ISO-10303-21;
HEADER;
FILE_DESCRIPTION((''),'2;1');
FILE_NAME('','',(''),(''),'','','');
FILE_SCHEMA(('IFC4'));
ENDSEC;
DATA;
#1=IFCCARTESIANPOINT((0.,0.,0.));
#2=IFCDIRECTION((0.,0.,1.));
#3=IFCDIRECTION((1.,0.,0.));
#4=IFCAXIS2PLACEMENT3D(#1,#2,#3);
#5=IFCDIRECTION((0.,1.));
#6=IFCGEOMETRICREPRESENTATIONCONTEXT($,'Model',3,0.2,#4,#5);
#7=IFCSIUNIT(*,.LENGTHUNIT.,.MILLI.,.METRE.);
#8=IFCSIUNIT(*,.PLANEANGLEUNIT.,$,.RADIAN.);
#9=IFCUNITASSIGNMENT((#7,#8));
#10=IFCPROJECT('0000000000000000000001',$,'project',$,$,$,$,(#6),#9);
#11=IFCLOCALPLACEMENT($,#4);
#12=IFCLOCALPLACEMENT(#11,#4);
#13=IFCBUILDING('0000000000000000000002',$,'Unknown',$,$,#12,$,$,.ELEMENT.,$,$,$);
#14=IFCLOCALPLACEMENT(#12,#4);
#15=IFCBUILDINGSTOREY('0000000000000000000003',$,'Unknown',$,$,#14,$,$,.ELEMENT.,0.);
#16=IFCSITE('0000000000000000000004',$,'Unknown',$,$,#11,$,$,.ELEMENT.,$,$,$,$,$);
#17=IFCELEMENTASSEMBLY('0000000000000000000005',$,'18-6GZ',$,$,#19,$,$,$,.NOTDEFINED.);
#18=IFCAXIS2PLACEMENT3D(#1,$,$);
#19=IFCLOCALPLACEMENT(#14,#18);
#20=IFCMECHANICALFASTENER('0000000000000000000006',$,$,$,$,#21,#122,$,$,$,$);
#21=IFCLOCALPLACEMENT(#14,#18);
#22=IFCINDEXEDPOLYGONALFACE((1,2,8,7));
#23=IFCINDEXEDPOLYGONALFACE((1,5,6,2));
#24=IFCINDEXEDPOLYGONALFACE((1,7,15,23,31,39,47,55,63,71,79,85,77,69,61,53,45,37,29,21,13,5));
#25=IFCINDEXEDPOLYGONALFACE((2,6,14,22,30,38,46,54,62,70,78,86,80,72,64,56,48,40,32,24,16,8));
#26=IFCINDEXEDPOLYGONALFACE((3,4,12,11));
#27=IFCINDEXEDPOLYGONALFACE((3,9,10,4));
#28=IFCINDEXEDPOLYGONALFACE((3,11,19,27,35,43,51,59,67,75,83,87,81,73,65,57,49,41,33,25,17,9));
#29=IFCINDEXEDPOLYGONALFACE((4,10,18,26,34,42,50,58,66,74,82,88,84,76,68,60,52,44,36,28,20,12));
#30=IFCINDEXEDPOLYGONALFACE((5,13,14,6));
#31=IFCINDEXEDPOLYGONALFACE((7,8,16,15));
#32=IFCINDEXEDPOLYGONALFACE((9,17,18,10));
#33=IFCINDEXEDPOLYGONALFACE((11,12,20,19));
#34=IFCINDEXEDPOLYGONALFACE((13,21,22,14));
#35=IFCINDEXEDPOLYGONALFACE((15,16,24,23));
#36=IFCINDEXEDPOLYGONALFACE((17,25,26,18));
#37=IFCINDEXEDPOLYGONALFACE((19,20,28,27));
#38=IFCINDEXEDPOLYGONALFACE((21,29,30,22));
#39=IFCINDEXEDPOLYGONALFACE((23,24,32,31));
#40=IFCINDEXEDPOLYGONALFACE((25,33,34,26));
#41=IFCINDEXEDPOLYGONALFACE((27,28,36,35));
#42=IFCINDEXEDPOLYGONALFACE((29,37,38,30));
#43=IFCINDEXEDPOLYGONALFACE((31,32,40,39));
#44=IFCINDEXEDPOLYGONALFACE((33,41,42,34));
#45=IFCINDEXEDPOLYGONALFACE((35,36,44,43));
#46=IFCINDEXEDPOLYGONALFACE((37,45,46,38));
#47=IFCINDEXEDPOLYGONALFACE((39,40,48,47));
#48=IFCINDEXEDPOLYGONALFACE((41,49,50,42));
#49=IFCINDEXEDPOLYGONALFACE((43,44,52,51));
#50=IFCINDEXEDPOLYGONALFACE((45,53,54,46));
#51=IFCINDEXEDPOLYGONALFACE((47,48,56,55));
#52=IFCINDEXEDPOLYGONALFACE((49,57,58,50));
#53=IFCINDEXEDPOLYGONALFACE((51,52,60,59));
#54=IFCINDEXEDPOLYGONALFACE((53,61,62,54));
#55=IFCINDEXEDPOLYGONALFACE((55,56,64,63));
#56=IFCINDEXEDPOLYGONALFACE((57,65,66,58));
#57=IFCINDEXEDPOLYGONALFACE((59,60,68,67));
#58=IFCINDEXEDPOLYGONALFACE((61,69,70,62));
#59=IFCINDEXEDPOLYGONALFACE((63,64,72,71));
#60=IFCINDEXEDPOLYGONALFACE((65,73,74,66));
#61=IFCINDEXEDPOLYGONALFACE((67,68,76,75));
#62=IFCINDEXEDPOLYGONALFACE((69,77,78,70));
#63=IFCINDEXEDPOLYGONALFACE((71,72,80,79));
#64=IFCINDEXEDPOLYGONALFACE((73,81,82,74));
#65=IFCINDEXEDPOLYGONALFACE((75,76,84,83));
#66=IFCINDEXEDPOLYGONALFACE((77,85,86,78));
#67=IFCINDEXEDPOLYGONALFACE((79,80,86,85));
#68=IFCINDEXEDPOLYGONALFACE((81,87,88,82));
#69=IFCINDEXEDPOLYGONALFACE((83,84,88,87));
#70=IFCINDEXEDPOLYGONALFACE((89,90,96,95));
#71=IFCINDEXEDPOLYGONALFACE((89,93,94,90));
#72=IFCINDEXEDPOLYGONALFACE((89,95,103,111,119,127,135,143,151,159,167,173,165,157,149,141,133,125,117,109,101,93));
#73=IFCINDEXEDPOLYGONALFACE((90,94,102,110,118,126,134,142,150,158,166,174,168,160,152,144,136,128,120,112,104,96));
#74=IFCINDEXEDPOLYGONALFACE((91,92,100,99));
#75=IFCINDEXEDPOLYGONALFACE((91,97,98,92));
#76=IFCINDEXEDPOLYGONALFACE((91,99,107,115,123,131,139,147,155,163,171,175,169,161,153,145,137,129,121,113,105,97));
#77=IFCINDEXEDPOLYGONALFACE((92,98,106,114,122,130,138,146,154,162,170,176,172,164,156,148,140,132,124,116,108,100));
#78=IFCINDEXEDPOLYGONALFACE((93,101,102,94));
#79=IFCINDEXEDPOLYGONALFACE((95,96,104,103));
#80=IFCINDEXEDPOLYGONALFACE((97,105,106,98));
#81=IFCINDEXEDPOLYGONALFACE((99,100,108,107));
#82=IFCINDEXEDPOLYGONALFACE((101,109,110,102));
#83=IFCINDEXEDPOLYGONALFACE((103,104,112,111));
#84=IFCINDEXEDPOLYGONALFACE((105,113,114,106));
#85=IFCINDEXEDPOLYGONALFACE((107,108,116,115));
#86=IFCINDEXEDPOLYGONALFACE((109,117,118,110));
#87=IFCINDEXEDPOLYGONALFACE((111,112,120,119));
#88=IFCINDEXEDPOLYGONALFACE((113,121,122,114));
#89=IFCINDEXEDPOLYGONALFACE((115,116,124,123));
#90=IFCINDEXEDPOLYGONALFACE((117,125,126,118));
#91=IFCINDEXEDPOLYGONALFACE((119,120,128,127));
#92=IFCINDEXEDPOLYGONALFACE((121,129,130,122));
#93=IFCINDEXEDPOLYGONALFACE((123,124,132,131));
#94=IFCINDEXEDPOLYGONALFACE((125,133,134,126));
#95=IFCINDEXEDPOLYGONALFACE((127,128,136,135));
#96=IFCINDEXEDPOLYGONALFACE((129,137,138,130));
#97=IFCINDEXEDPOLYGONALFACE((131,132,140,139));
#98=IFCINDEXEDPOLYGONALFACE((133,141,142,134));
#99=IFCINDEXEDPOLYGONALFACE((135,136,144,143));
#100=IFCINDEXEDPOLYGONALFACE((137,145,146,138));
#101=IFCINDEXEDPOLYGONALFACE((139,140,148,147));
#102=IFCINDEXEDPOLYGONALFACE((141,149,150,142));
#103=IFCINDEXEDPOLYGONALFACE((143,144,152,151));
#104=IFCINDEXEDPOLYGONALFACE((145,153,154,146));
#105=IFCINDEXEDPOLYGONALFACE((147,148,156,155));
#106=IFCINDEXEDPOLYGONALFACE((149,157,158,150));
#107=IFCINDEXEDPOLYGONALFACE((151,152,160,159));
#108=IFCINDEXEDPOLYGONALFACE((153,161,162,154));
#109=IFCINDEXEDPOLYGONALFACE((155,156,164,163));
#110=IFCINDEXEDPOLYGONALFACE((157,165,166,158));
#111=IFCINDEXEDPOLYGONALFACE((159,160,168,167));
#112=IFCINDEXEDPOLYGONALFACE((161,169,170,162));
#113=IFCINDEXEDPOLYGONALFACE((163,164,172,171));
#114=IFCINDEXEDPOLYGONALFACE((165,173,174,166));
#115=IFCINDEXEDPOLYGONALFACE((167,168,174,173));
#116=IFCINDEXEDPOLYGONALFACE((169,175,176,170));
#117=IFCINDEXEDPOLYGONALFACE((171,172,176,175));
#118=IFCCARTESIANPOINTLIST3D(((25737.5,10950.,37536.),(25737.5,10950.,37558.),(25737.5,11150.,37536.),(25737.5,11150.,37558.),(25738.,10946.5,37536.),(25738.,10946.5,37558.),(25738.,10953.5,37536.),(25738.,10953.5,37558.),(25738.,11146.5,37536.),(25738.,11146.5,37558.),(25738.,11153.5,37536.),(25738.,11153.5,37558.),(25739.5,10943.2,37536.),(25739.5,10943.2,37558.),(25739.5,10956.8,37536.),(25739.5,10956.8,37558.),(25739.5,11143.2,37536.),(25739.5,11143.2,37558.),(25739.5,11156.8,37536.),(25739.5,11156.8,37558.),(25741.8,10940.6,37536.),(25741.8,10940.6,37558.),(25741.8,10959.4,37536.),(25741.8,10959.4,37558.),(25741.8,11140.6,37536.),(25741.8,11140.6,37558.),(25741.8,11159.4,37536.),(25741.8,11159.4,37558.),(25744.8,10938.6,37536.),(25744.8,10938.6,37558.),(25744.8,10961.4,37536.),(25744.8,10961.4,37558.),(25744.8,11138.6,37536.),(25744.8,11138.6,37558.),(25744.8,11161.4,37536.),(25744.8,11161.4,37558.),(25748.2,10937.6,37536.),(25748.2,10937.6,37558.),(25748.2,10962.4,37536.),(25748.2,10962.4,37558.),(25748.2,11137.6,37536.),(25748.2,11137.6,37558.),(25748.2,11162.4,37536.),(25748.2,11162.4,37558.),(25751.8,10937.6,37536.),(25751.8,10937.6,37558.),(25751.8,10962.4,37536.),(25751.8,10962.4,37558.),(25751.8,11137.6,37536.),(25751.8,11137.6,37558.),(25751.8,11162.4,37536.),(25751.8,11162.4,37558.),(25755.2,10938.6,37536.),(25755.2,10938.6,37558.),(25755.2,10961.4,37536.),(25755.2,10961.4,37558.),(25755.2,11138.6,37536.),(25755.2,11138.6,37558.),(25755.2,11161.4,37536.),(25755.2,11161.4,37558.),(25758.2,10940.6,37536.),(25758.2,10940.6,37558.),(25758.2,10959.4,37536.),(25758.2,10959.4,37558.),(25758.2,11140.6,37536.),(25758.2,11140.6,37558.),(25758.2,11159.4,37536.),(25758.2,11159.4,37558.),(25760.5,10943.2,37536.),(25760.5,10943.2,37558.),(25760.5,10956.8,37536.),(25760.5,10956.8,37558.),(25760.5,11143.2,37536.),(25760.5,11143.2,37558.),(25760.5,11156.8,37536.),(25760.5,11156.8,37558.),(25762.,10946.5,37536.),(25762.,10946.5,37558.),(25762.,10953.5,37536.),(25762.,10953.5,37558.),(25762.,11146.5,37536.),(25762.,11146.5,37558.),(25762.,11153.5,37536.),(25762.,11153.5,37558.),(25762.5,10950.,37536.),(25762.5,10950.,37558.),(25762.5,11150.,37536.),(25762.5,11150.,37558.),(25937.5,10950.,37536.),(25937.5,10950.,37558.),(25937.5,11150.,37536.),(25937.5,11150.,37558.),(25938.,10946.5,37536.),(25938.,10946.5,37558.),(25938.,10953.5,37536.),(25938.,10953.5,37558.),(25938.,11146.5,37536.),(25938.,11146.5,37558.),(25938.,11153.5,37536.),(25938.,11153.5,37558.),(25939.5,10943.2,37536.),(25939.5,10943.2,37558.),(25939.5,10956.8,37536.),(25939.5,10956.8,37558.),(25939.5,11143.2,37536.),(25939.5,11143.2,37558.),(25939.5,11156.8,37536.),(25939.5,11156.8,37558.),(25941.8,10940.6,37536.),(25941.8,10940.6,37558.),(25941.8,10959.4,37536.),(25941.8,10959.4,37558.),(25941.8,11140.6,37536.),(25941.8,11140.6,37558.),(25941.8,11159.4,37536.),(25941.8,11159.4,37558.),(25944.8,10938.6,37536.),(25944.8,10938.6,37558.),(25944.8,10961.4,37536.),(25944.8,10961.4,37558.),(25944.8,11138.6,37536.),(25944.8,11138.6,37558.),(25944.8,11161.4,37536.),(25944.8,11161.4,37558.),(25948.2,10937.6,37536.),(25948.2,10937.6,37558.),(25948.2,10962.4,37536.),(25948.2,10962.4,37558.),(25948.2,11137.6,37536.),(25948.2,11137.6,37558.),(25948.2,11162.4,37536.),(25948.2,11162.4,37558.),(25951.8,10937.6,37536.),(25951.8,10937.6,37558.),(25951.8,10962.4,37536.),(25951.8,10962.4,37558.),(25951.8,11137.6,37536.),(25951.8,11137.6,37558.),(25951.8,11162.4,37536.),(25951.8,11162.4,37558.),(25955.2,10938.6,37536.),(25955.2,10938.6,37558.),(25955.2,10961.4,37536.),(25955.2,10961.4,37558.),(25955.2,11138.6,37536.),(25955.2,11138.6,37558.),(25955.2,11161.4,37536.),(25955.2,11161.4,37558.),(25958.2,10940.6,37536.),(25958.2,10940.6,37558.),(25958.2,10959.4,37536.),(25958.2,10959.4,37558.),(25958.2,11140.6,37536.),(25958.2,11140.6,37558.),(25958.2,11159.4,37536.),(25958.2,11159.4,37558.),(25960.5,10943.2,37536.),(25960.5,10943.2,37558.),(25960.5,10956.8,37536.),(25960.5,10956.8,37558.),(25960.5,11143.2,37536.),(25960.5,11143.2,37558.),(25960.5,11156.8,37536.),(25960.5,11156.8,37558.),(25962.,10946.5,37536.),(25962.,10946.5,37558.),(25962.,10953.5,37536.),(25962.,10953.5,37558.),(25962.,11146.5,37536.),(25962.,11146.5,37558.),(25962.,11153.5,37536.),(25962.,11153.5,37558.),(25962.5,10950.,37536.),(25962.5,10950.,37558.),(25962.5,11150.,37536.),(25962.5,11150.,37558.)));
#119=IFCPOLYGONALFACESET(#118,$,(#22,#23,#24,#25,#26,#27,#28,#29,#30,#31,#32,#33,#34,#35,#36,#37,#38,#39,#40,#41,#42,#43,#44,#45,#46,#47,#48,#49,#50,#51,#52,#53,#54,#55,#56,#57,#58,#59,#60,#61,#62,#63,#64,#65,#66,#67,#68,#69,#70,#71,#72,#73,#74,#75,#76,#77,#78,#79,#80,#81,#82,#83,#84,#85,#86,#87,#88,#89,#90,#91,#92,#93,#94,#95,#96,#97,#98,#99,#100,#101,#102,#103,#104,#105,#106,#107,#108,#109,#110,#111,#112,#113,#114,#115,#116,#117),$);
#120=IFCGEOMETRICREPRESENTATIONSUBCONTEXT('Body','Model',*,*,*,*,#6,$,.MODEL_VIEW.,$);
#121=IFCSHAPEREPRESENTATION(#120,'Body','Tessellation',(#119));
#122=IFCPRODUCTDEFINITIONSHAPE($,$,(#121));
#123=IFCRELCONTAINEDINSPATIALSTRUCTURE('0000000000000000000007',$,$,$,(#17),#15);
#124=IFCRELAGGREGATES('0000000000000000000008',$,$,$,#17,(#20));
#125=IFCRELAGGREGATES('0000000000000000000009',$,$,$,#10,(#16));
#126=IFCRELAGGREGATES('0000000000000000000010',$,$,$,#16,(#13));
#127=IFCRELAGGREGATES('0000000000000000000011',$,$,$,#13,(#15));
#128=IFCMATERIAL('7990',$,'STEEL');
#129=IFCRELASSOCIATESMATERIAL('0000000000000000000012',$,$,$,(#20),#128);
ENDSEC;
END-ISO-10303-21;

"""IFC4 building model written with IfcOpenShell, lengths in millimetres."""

from ifc_helpers import new_model, si_unit, direction, frame, origin_with_axes, place, context, subcontext, project, spatial, arc, indexed_curve, outline, extrude, source, transform, mapped, material, element, aggregate, save


model = new_model("IFC4")

# Units and contexts
model_context = context("Model", 3, precision=0.2, world=origin_with_axes(), true_north=direction((0.0, 1.0)))
body_context = subcontext(model_context, "Body", "Model", "MODEL_VIEW")
ifc_project = project(units=[si_unit("LENGTHUNIT", "METRE", prefix="MILLI"), si_unit("PLANEANGLEUNIT", "RADIAN")], contexts=[model_context])

# Site, building, storey
site_placement = place(None, origin_with_axes())
site = spatial("IfcSite", under=ifc_project, at=site_placement, Name="Unknown", CompositionType="ELEMENT")
building_placement = place(site_placement, origin_with_axes())
building = spatial("IfcBuilding", under=site, at=building_placement, Name="Unknown", CompositionType="ELEMENT")
storey_placement = place(building_placement, origin_with_axes())
storey = spatial("IfcBuildingStorey", under=building, at=storey_placement, Name="Unknown", CompositionType="ELEMENT", Elevation=0.0)

# Element assembly
assembly_1_placement = place(storey_placement, frame((25850.0, 11050.0, 35950.0), z_axis=(-1.0, 0.0, 0.0), x_axis=(0.0, 0.0, 1.0)))
assembly_1 = element("IfcElementAssembly", 1, at=assembly_1_placement, inside=storey, Name="18-6GZ", PredefinedType="NOTDEFINED")

# Mechanical fastener
ifc_material_1 = material(Name="7990", Category="STEEL")
placement_1 = place(assembly_1_placement, frame((1608.0, 0.0, 0.0), z_axis=(1.0, 0.0, 0.0), x_axis=(0.0, 1.0, 0.0)))
shared_shape_1 = source(origin_with_axes(), body_context, "Body", "SweptSolid", [
    extrude(outline(indexed_curve([(12.5, 0.0), (0.0, 12.5), (-12.5, 0.0), (0.0, -12.5)], segments=[arc(1, 2, 3), arc(3, 4, 1)])), frame((0.0, 0.0, 0.0), z_axis=(0.0, 0.0, -1.0), x_axis=(0.0, 1.0, 0.0)), (0.0, 0.0, 1.0), 22.0),
])
mechanical_fastener_1 = element("IfcMechanicalFastener", 2, at=placement_1, material=ifc_material_1, context=body_context, shape_type="MappedRepresentation", body=[
    mapped(shared_shape_1, transform((-100.0, -100.0, 0.0))),
    mapped(shared_shape_1, transform((100.0, -100.0, 0.0))),
    mapped(shared_shape_1, transform((-100.0, 100.0, 0.0))),
    mapped(shared_shape_1, transform((100.0, 100.0, 0.0))),
])
aggregate(assembly_1, [mechanical_fastener_1])

save(model, "model.ifc")
